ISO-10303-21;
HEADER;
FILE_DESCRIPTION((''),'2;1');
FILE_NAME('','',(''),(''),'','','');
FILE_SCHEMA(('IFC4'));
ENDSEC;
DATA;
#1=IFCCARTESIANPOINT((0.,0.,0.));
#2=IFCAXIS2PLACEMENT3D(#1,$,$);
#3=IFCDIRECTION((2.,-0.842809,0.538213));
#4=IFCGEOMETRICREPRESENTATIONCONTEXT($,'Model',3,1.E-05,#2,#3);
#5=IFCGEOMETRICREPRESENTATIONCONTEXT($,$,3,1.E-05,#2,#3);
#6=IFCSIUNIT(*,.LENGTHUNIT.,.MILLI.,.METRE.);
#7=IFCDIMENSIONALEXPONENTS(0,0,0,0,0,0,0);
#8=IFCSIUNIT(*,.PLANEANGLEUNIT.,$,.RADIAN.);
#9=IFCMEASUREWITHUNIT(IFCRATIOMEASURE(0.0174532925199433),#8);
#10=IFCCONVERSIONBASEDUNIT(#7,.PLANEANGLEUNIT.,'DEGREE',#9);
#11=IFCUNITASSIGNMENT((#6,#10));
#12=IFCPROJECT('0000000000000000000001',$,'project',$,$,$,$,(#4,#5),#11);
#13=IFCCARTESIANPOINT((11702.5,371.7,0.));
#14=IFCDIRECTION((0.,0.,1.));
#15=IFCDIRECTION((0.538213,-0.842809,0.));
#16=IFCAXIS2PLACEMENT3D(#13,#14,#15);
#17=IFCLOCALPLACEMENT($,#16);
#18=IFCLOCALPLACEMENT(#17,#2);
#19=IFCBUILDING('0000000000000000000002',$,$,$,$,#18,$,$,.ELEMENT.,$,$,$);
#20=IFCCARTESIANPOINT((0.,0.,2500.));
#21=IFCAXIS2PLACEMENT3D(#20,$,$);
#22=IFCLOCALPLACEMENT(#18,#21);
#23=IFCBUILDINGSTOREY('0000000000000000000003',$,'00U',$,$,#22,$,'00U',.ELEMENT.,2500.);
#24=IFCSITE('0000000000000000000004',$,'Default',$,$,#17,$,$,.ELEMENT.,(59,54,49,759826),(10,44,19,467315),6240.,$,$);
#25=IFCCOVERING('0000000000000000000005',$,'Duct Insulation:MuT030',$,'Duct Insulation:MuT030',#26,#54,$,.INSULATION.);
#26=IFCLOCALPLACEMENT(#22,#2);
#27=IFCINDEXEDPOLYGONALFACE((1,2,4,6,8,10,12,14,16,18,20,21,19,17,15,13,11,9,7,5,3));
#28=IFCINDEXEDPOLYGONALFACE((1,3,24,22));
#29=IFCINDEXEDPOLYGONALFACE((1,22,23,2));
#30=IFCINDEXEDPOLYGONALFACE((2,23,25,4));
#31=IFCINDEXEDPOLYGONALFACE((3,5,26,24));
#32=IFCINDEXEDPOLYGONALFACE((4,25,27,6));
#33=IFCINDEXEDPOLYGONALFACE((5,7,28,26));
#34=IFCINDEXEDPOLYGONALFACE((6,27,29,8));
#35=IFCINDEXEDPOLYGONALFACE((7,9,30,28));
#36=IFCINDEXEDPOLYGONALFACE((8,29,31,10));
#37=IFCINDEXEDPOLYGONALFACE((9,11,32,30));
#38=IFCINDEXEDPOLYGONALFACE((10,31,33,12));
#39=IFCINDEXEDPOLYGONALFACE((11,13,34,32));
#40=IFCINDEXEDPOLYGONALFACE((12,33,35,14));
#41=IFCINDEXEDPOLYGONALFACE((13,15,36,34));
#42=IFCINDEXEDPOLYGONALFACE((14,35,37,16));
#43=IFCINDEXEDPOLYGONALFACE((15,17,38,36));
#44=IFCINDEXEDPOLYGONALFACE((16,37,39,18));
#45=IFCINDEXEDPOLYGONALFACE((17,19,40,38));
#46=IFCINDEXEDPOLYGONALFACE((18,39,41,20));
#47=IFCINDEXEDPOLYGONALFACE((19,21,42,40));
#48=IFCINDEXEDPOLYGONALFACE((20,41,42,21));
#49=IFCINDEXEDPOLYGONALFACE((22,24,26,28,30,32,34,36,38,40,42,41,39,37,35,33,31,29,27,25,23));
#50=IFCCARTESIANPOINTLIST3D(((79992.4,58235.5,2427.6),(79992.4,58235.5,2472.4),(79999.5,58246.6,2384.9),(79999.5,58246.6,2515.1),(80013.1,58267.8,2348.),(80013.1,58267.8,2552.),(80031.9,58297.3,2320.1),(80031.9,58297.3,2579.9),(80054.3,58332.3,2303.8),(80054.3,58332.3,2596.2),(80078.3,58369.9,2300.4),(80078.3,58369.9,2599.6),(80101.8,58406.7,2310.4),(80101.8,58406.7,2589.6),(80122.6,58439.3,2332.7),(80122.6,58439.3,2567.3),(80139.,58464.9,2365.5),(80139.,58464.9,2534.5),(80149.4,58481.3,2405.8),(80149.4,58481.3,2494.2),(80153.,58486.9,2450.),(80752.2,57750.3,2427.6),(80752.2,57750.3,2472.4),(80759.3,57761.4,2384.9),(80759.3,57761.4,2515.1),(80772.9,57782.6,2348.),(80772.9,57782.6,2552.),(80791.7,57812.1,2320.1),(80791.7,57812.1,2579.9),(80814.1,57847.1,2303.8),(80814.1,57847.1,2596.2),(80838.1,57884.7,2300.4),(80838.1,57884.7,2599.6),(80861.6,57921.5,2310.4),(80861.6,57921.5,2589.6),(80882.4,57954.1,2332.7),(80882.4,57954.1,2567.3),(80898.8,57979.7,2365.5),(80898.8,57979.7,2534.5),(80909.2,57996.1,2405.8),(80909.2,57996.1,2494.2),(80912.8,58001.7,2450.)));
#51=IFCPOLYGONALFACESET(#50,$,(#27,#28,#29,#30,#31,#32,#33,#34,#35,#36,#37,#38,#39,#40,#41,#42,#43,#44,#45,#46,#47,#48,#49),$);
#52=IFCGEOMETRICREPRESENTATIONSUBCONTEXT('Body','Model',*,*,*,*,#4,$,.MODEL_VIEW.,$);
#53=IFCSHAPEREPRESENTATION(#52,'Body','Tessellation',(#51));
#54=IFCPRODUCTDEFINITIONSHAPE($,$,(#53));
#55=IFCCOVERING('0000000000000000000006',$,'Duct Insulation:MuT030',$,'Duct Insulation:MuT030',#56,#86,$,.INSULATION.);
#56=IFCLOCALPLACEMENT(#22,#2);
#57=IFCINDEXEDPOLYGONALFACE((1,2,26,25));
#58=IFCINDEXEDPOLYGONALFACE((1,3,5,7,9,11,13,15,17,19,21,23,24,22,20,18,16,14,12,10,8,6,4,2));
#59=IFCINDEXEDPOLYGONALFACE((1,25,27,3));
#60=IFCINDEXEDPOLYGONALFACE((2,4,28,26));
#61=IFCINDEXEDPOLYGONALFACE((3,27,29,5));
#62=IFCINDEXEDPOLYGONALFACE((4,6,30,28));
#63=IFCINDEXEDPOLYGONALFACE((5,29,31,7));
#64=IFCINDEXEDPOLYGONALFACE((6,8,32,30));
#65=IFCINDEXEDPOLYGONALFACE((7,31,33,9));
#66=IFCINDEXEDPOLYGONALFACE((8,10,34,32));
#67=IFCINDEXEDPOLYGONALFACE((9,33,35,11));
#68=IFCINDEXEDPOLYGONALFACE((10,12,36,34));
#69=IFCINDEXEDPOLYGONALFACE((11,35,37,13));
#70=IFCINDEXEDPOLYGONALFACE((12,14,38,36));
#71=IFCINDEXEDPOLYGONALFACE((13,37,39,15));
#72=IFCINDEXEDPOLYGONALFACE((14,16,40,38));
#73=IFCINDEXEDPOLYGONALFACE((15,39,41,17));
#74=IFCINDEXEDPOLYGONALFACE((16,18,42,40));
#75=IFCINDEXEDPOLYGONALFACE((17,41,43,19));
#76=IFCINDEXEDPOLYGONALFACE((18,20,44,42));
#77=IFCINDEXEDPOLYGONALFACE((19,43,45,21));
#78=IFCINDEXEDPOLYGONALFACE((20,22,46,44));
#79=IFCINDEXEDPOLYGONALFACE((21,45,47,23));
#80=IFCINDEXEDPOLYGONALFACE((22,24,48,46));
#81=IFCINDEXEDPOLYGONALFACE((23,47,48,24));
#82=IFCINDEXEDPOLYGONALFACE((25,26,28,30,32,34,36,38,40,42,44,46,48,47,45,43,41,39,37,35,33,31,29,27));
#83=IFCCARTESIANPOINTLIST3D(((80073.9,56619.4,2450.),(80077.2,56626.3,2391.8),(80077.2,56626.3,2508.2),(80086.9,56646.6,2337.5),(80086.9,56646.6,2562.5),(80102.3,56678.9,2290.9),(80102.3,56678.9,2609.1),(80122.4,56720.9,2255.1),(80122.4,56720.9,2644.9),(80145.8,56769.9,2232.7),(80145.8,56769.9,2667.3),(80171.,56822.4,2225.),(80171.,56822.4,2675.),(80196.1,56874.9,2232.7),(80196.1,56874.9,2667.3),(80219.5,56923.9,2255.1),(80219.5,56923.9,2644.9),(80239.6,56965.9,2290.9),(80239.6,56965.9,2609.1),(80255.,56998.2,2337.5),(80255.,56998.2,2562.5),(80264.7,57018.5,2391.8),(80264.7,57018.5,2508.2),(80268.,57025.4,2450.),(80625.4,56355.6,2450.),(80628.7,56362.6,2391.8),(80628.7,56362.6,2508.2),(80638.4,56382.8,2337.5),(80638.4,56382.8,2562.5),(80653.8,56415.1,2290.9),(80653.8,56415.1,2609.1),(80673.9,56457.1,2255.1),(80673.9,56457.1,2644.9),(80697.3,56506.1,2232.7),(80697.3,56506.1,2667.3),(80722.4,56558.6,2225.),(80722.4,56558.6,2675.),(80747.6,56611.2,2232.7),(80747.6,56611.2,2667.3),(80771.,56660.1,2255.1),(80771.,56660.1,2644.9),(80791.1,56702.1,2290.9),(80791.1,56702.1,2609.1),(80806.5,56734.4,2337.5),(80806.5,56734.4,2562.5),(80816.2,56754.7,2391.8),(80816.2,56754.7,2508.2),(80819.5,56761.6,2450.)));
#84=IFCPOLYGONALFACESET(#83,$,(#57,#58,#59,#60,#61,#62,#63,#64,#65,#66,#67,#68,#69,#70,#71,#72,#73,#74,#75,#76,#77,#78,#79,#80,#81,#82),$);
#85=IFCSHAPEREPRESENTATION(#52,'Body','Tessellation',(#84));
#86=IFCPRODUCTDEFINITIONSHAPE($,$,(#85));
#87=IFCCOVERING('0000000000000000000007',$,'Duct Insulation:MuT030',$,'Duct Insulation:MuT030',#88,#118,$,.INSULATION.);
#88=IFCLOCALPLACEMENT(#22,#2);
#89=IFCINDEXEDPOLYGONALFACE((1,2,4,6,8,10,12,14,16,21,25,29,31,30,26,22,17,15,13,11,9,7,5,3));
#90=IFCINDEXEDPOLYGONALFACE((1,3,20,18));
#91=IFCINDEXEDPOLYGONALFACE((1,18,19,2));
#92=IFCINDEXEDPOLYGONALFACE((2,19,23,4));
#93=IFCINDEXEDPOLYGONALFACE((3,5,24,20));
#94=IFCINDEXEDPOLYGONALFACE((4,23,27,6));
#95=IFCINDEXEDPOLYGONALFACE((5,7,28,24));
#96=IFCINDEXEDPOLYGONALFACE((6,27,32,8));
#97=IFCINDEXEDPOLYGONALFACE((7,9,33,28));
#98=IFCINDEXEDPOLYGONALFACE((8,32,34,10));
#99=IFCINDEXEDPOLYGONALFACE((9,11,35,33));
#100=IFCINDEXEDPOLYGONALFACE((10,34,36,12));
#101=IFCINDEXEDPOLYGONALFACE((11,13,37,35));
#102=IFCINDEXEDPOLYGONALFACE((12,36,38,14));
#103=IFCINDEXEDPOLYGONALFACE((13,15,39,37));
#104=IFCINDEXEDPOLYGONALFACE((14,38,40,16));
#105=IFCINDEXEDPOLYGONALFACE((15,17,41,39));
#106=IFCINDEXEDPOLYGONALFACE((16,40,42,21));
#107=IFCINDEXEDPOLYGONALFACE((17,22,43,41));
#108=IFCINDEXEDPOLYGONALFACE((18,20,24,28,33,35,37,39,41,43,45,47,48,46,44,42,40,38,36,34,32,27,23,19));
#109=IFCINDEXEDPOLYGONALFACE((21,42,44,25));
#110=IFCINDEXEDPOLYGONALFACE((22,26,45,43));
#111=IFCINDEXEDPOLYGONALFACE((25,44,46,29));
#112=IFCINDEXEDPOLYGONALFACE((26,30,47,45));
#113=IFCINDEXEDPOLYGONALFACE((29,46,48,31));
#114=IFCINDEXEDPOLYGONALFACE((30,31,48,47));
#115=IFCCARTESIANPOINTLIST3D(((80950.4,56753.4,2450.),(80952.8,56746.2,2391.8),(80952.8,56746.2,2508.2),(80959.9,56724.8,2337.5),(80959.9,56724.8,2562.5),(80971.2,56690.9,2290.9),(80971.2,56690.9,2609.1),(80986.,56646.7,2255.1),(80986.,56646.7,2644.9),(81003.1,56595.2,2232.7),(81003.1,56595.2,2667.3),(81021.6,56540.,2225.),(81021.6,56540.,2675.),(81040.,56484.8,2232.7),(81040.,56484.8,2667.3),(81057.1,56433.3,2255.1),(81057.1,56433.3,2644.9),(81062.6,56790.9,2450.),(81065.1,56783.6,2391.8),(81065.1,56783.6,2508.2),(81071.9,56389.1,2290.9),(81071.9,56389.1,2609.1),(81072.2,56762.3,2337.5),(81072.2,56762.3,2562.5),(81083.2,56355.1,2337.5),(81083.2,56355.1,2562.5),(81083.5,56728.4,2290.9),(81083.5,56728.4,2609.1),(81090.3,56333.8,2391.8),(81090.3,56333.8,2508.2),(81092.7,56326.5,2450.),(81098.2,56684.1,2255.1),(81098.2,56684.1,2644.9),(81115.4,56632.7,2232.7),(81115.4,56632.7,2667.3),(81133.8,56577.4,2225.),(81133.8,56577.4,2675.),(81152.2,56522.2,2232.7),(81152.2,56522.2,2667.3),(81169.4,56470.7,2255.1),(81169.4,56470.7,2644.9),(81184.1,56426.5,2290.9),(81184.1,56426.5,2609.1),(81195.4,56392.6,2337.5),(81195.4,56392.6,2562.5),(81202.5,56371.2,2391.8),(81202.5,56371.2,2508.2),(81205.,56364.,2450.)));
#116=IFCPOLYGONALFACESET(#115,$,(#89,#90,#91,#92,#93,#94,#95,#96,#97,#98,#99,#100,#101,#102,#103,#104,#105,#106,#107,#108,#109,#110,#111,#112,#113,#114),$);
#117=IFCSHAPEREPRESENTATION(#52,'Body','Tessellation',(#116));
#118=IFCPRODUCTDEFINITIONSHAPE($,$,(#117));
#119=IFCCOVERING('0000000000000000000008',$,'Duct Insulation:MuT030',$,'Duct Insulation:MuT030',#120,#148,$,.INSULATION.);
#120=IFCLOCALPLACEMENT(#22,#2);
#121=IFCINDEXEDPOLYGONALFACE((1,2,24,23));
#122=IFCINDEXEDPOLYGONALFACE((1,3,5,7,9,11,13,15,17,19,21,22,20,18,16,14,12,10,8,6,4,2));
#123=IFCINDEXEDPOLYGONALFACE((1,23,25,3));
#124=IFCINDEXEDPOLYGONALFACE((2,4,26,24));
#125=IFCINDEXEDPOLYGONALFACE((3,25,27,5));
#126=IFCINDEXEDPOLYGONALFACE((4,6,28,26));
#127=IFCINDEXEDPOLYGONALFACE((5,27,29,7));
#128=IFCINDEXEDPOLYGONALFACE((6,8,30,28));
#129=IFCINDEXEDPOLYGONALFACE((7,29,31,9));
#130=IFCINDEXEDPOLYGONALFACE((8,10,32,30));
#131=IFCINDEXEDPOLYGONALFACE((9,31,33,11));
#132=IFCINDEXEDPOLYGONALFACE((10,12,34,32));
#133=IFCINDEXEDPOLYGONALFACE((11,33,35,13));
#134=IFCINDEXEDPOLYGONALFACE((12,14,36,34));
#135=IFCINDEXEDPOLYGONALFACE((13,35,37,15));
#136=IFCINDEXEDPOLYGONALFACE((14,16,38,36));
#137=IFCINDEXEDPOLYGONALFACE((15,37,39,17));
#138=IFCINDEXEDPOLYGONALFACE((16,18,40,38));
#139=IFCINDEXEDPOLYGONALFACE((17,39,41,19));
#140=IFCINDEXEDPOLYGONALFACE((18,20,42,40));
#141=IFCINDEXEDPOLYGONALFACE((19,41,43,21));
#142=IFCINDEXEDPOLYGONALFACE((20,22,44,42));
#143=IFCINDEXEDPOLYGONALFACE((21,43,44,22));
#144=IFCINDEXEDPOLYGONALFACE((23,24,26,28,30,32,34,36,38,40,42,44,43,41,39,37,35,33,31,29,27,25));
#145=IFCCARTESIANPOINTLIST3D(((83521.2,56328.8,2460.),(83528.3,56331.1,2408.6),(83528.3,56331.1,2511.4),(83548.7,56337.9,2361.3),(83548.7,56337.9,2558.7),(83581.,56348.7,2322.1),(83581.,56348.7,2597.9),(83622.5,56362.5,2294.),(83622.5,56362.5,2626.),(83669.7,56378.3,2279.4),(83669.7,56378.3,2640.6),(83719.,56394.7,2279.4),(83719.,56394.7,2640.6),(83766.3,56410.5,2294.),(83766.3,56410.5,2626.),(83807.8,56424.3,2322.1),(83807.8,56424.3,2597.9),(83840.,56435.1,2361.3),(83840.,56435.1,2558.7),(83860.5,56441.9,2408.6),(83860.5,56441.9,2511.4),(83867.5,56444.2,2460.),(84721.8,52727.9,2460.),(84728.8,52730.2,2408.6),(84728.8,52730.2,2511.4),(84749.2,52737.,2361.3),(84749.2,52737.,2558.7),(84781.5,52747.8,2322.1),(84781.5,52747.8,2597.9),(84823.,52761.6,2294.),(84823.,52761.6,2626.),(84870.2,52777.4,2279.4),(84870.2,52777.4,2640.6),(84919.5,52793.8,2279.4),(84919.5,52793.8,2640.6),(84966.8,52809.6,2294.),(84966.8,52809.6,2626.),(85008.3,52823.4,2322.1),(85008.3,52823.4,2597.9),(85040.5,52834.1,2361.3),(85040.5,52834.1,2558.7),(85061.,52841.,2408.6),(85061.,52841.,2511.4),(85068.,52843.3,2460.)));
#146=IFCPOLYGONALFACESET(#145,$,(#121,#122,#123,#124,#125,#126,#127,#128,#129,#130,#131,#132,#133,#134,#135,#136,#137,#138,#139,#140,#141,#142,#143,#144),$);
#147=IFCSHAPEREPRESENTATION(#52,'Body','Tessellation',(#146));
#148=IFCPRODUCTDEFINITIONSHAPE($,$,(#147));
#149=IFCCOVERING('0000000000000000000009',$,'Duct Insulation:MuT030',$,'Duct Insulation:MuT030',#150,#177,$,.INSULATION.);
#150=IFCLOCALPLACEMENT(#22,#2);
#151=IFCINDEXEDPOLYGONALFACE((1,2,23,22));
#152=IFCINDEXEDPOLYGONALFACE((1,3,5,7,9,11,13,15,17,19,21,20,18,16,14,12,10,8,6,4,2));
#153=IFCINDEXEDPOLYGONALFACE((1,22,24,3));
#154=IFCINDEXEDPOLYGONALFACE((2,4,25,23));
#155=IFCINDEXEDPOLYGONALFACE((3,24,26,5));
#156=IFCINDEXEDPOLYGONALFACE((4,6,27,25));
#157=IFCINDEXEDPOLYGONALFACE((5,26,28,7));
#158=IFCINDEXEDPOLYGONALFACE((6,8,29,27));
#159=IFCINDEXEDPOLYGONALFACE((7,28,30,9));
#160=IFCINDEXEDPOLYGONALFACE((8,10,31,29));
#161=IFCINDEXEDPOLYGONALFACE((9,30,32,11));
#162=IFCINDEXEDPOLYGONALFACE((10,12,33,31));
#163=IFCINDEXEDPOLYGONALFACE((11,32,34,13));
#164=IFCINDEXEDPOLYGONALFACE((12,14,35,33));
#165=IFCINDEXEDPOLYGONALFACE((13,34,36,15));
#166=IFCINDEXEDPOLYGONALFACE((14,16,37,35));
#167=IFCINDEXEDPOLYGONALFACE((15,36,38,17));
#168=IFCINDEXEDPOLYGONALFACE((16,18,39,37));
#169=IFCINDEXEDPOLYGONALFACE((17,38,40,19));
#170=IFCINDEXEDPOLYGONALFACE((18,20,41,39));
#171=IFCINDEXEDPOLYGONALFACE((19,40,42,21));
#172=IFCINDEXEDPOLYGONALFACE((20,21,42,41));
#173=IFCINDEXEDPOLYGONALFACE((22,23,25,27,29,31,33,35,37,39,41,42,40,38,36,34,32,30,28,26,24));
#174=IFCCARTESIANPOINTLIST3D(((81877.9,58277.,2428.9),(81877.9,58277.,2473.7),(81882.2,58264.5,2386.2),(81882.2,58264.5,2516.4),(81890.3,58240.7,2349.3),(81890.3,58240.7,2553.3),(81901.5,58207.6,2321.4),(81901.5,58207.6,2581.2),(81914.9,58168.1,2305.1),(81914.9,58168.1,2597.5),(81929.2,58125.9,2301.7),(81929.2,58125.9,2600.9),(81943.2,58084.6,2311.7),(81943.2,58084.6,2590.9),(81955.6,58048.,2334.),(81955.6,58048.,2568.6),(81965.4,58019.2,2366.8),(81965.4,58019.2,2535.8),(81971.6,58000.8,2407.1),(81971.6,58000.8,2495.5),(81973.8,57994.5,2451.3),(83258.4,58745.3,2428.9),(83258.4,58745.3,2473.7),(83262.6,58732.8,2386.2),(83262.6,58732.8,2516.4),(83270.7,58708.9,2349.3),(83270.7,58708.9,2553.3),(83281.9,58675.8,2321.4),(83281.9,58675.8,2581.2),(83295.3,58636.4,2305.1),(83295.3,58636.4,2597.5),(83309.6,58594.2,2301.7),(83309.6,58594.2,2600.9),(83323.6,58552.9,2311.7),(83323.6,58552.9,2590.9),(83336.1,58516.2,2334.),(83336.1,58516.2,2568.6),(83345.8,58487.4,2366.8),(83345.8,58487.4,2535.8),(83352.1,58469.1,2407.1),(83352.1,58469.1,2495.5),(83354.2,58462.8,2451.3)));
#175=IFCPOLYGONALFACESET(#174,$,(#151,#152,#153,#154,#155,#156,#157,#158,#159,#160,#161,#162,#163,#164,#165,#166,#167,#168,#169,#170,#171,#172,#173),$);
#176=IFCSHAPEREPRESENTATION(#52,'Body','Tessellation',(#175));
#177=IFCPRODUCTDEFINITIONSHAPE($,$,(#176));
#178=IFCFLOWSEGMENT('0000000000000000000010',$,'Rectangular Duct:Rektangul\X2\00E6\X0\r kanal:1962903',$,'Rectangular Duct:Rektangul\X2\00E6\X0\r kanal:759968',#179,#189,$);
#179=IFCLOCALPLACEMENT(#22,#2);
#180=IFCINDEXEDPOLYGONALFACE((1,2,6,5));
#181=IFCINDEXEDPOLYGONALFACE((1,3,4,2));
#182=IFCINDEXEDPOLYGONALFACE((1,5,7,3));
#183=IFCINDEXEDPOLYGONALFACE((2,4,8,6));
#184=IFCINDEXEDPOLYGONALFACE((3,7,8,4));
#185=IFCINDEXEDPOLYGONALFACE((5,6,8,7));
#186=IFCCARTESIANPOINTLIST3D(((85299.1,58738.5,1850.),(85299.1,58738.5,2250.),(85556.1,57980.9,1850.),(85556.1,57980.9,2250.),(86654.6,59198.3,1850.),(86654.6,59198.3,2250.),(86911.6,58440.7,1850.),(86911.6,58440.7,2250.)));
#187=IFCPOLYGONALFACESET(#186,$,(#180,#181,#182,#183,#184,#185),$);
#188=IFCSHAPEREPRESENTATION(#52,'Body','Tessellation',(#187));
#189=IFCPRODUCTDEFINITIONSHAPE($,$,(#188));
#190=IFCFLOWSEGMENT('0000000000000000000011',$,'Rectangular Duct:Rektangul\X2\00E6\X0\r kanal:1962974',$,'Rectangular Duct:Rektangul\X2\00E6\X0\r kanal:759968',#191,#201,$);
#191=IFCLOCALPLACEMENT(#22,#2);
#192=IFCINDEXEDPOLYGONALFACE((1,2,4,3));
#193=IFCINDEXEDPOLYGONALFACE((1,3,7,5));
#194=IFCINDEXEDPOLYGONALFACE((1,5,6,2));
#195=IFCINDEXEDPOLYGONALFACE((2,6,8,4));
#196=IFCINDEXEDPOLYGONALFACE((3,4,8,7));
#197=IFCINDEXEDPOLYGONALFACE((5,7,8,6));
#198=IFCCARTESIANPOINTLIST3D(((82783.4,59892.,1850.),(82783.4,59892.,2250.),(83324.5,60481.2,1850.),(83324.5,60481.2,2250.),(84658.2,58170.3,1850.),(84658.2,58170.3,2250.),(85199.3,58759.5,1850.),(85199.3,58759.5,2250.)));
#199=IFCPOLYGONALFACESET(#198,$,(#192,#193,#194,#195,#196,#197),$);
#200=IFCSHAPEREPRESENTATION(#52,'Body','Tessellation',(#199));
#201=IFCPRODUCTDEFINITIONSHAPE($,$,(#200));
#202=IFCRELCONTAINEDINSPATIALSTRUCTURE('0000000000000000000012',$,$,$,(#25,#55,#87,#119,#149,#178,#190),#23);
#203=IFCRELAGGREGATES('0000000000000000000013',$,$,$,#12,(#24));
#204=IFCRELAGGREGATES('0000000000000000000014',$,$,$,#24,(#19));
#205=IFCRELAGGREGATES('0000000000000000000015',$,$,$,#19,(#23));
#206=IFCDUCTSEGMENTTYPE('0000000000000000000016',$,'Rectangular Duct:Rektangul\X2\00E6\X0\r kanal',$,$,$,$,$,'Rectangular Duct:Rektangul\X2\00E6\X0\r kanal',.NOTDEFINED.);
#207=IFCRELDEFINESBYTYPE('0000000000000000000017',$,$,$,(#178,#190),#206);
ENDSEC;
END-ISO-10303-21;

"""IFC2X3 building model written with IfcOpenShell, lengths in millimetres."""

from ifc_helpers import new_model, entity, si_unit, converted_unit, direction, frame, frame_2d, origin, origin_2d_with_axis, place, context, subcontext, project, spatial, rectangle, circle, extrude, type_object, element, save


model = new_model("IFC2X3")

# Units and contexts
model_context = context("Model", 3, precision=1e-05, world=origin(), true_north=direction((2.0, -0.842809, 0.538213)))
context_of_model = context(None, 3, precision=1e-05, world=origin(), true_north=direction((2.0, -0.842809, 0.538213)))
body_context = subcontext(model_context, "Body", "Model", "MODEL_VIEW")
ifc_project = project(units=[si_unit("LENGTHUNIT", "METRE", prefix="MILLI"), converted_unit("PLANEANGLEUNIT", "DEGREE", entity("IfcRatioMeasure", 0.0174532925199433), si_unit("PLANEANGLEUNIT", "RADIAN"), dimensions=[0, 0, 0, 0, 0, 0, 0])], contexts=[model_context, context_of_model])

# Site, building, storey
site_placement = place(None, frame((11702.5, 371.7, 0.0), z_axis=(0.0, 0.0, 1.0), x_axis=(0.538213, -0.842809, 0.0)))
site = spatial("IfcSite", under=ifc_project, at=site_placement, Name="Default", CompositionType="ELEMENT", RefLatitude=(59, 54, 49, 759826), RefLongitude=(10, 44, 19, 467315), RefElevation=6240.0)
building_placement = place(site_placement, origin())
building = spatial("IfcBuilding", under=site, at=building_placement, CompositionType="ELEMENT")
storey_placement = place(building_placement, frame((0.0, 0.0, 2500.0)))
storey = spatial("IfcBuildingStorey", under=building, at=storey_placement, Name="00U", LongName="00U", CompositionType="ELEMENT", Elevation=2500.0)

# Coverings
covering_1_placement = place(storey_placement, origin())
element("IfcCovering", 1, at=covering_1_placement, inside=storey, Name="Duct Insulation:MuT030", ObjectType="Duct Insulation:MuT030", PredefinedType="INSULATION", context=body_context, shape_type="SweptSolid", body=[
    extrude(circle(Radius=150.0, at=origin_2d_with_axis()), frame((80072.3, 58360.5, 2450.0), z_axis=(0.842809, -0.538213, 0.0), x_axis=(0.538213, 0.842809, 0.0)), (0.0, 0.0, 1.0), 901.5),
])
covering_2_placement = place(storey_placement, origin())
element("IfcCovering", 2, at=covering_2_placement, inside=storey, Name="Duct Insulation:MuT030", ObjectType="Duct Insulation:MuT030", PredefinedType="INSULATION", context=body_context, shape_type="SweptSolid", body=[
    extrude(circle(Radius=225.0, at=origin_2d_with_axis()), frame((80722.4, 56558.6, 2450.0), z_axis=(-0.902118, 0.431489, 0.0), x_axis=(0.431489, 0.902118, 0.0)), (0.0, 0.0, 1.0), 611.3),
])
covering_3_placement = place(storey_placement, origin())
element("IfcCovering", 3, at=covering_3_placement, inside=storey, Name="Duct Insulation:MuT030", ObjectType="Duct Insulation:MuT030", PredefinedType="INSULATION", context=body_context, shape_type="SweptSolid", body=[
    extrude(circle(Radius=225.0, at=origin_2d_with_axis()), frame((81021.6, 56540.0, 2450.0), z_axis=(0.948667, 0.316277, 0.0), x_axis=(-0.316277, 0.948667, 0.0)), (0.0, 0.0, 1.0), 118.3),
])
covering_4_placement = place(storey_placement, origin())
element("IfcCovering", 4, at=covering_4_placement, inside=storey, Name="Duct Insulation:MuT030", ObjectType="Duct Insulation:MuT030", PredefinedType="INSULATION", context=body_context, shape_type="SweptSolid", body=[
    extrude(circle(Radius=182.5, at=origin_2d_with_axis()), frame((83694.4, 56386.5, 2460.0), z_axis=(0.316277, -0.948667, 0.0), x_axis=(-0.948667, -0.316277, 0.0)), (0.0, 0.0, 1.0), 3795.8),
])
covering_5_placement = place(storey_placement, origin())
element("IfcCovering", 5, at=covering_5_placement, inside=storey, Name="Duct Insulation:MuT030", ObjectType="Duct Insulation:MuT030", PredefinedType="INSULATION", context=body_context, shape_type="SweptSolid", body=[
    extrude(circle(Radius=150.0, at=origin_2d_with_axis()), frame((81925.6, 58136.5, 2451.3), z_axis=(0.946996, 0.321246, 0.0), x_axis=(0.321246, -0.946996, 0.0)), (0.0, 0.0, 1.0), 1457.7),
])

# Flow segments
duct_segment_type_1 = type_object("IfcDuctSegmentType", Name="Rectangular Duct:Rektangulær kanal", ElementType="Rectangular Duct:Rektangulær kanal", PredefinedType="NOTDEFINED")
flow_segment_1_placement = place(storey_placement, origin())
element("IfcFlowSegment", 6, at=flow_segment_1_placement, inside=storey, type_object=duct_segment_type_1, Name="Rectangular Duct:Rektangulær kanal:1962903", ObjectType="Rectangular Duct:Rektangulær kanal:759968", context=body_context, shape_type="SweptSolid", body=[
    extrude(rectangle(XDim=1431.5, YDim=800.0, at=frame_2d((0.0, 0.0), x_axis=(1.0, 0.0))), frame((86105.3, 58589.6, 1850.0), z_axis=(0.0, 0.0, 1.0), x_axis=(-0.946996, -0.321246, 0.0)), (0.0, 0.0, 1.0), 400.0),
])
flow_segment_2_placement = place(storey_placement, origin())
element("IfcFlowSegment", 7, at=flow_segment_2_placement, inside=storey, type_object=duct_segment_type_1, Name="Rectangular Duct:Rektangulær kanal:1962974", ObjectType="Rectangular Duct:Rektangulær kanal:759968", context=body_context, shape_type="SweptSolid", body=[
    extrude(rectangle(XDim=2545.4, YDim=800.0, at=frame_2d((0.0, 0.0), x_axis=(1.0, 0.0))), frame((83991.3, 59325.8, 1850.0), z_axis=(0.0, 0.0, 1.0), x_axis=(-0.736545, 0.676389, 0.0)), (0.0, 0.0, 1.0), 400.0),
])

save(model, "model.ifc")
